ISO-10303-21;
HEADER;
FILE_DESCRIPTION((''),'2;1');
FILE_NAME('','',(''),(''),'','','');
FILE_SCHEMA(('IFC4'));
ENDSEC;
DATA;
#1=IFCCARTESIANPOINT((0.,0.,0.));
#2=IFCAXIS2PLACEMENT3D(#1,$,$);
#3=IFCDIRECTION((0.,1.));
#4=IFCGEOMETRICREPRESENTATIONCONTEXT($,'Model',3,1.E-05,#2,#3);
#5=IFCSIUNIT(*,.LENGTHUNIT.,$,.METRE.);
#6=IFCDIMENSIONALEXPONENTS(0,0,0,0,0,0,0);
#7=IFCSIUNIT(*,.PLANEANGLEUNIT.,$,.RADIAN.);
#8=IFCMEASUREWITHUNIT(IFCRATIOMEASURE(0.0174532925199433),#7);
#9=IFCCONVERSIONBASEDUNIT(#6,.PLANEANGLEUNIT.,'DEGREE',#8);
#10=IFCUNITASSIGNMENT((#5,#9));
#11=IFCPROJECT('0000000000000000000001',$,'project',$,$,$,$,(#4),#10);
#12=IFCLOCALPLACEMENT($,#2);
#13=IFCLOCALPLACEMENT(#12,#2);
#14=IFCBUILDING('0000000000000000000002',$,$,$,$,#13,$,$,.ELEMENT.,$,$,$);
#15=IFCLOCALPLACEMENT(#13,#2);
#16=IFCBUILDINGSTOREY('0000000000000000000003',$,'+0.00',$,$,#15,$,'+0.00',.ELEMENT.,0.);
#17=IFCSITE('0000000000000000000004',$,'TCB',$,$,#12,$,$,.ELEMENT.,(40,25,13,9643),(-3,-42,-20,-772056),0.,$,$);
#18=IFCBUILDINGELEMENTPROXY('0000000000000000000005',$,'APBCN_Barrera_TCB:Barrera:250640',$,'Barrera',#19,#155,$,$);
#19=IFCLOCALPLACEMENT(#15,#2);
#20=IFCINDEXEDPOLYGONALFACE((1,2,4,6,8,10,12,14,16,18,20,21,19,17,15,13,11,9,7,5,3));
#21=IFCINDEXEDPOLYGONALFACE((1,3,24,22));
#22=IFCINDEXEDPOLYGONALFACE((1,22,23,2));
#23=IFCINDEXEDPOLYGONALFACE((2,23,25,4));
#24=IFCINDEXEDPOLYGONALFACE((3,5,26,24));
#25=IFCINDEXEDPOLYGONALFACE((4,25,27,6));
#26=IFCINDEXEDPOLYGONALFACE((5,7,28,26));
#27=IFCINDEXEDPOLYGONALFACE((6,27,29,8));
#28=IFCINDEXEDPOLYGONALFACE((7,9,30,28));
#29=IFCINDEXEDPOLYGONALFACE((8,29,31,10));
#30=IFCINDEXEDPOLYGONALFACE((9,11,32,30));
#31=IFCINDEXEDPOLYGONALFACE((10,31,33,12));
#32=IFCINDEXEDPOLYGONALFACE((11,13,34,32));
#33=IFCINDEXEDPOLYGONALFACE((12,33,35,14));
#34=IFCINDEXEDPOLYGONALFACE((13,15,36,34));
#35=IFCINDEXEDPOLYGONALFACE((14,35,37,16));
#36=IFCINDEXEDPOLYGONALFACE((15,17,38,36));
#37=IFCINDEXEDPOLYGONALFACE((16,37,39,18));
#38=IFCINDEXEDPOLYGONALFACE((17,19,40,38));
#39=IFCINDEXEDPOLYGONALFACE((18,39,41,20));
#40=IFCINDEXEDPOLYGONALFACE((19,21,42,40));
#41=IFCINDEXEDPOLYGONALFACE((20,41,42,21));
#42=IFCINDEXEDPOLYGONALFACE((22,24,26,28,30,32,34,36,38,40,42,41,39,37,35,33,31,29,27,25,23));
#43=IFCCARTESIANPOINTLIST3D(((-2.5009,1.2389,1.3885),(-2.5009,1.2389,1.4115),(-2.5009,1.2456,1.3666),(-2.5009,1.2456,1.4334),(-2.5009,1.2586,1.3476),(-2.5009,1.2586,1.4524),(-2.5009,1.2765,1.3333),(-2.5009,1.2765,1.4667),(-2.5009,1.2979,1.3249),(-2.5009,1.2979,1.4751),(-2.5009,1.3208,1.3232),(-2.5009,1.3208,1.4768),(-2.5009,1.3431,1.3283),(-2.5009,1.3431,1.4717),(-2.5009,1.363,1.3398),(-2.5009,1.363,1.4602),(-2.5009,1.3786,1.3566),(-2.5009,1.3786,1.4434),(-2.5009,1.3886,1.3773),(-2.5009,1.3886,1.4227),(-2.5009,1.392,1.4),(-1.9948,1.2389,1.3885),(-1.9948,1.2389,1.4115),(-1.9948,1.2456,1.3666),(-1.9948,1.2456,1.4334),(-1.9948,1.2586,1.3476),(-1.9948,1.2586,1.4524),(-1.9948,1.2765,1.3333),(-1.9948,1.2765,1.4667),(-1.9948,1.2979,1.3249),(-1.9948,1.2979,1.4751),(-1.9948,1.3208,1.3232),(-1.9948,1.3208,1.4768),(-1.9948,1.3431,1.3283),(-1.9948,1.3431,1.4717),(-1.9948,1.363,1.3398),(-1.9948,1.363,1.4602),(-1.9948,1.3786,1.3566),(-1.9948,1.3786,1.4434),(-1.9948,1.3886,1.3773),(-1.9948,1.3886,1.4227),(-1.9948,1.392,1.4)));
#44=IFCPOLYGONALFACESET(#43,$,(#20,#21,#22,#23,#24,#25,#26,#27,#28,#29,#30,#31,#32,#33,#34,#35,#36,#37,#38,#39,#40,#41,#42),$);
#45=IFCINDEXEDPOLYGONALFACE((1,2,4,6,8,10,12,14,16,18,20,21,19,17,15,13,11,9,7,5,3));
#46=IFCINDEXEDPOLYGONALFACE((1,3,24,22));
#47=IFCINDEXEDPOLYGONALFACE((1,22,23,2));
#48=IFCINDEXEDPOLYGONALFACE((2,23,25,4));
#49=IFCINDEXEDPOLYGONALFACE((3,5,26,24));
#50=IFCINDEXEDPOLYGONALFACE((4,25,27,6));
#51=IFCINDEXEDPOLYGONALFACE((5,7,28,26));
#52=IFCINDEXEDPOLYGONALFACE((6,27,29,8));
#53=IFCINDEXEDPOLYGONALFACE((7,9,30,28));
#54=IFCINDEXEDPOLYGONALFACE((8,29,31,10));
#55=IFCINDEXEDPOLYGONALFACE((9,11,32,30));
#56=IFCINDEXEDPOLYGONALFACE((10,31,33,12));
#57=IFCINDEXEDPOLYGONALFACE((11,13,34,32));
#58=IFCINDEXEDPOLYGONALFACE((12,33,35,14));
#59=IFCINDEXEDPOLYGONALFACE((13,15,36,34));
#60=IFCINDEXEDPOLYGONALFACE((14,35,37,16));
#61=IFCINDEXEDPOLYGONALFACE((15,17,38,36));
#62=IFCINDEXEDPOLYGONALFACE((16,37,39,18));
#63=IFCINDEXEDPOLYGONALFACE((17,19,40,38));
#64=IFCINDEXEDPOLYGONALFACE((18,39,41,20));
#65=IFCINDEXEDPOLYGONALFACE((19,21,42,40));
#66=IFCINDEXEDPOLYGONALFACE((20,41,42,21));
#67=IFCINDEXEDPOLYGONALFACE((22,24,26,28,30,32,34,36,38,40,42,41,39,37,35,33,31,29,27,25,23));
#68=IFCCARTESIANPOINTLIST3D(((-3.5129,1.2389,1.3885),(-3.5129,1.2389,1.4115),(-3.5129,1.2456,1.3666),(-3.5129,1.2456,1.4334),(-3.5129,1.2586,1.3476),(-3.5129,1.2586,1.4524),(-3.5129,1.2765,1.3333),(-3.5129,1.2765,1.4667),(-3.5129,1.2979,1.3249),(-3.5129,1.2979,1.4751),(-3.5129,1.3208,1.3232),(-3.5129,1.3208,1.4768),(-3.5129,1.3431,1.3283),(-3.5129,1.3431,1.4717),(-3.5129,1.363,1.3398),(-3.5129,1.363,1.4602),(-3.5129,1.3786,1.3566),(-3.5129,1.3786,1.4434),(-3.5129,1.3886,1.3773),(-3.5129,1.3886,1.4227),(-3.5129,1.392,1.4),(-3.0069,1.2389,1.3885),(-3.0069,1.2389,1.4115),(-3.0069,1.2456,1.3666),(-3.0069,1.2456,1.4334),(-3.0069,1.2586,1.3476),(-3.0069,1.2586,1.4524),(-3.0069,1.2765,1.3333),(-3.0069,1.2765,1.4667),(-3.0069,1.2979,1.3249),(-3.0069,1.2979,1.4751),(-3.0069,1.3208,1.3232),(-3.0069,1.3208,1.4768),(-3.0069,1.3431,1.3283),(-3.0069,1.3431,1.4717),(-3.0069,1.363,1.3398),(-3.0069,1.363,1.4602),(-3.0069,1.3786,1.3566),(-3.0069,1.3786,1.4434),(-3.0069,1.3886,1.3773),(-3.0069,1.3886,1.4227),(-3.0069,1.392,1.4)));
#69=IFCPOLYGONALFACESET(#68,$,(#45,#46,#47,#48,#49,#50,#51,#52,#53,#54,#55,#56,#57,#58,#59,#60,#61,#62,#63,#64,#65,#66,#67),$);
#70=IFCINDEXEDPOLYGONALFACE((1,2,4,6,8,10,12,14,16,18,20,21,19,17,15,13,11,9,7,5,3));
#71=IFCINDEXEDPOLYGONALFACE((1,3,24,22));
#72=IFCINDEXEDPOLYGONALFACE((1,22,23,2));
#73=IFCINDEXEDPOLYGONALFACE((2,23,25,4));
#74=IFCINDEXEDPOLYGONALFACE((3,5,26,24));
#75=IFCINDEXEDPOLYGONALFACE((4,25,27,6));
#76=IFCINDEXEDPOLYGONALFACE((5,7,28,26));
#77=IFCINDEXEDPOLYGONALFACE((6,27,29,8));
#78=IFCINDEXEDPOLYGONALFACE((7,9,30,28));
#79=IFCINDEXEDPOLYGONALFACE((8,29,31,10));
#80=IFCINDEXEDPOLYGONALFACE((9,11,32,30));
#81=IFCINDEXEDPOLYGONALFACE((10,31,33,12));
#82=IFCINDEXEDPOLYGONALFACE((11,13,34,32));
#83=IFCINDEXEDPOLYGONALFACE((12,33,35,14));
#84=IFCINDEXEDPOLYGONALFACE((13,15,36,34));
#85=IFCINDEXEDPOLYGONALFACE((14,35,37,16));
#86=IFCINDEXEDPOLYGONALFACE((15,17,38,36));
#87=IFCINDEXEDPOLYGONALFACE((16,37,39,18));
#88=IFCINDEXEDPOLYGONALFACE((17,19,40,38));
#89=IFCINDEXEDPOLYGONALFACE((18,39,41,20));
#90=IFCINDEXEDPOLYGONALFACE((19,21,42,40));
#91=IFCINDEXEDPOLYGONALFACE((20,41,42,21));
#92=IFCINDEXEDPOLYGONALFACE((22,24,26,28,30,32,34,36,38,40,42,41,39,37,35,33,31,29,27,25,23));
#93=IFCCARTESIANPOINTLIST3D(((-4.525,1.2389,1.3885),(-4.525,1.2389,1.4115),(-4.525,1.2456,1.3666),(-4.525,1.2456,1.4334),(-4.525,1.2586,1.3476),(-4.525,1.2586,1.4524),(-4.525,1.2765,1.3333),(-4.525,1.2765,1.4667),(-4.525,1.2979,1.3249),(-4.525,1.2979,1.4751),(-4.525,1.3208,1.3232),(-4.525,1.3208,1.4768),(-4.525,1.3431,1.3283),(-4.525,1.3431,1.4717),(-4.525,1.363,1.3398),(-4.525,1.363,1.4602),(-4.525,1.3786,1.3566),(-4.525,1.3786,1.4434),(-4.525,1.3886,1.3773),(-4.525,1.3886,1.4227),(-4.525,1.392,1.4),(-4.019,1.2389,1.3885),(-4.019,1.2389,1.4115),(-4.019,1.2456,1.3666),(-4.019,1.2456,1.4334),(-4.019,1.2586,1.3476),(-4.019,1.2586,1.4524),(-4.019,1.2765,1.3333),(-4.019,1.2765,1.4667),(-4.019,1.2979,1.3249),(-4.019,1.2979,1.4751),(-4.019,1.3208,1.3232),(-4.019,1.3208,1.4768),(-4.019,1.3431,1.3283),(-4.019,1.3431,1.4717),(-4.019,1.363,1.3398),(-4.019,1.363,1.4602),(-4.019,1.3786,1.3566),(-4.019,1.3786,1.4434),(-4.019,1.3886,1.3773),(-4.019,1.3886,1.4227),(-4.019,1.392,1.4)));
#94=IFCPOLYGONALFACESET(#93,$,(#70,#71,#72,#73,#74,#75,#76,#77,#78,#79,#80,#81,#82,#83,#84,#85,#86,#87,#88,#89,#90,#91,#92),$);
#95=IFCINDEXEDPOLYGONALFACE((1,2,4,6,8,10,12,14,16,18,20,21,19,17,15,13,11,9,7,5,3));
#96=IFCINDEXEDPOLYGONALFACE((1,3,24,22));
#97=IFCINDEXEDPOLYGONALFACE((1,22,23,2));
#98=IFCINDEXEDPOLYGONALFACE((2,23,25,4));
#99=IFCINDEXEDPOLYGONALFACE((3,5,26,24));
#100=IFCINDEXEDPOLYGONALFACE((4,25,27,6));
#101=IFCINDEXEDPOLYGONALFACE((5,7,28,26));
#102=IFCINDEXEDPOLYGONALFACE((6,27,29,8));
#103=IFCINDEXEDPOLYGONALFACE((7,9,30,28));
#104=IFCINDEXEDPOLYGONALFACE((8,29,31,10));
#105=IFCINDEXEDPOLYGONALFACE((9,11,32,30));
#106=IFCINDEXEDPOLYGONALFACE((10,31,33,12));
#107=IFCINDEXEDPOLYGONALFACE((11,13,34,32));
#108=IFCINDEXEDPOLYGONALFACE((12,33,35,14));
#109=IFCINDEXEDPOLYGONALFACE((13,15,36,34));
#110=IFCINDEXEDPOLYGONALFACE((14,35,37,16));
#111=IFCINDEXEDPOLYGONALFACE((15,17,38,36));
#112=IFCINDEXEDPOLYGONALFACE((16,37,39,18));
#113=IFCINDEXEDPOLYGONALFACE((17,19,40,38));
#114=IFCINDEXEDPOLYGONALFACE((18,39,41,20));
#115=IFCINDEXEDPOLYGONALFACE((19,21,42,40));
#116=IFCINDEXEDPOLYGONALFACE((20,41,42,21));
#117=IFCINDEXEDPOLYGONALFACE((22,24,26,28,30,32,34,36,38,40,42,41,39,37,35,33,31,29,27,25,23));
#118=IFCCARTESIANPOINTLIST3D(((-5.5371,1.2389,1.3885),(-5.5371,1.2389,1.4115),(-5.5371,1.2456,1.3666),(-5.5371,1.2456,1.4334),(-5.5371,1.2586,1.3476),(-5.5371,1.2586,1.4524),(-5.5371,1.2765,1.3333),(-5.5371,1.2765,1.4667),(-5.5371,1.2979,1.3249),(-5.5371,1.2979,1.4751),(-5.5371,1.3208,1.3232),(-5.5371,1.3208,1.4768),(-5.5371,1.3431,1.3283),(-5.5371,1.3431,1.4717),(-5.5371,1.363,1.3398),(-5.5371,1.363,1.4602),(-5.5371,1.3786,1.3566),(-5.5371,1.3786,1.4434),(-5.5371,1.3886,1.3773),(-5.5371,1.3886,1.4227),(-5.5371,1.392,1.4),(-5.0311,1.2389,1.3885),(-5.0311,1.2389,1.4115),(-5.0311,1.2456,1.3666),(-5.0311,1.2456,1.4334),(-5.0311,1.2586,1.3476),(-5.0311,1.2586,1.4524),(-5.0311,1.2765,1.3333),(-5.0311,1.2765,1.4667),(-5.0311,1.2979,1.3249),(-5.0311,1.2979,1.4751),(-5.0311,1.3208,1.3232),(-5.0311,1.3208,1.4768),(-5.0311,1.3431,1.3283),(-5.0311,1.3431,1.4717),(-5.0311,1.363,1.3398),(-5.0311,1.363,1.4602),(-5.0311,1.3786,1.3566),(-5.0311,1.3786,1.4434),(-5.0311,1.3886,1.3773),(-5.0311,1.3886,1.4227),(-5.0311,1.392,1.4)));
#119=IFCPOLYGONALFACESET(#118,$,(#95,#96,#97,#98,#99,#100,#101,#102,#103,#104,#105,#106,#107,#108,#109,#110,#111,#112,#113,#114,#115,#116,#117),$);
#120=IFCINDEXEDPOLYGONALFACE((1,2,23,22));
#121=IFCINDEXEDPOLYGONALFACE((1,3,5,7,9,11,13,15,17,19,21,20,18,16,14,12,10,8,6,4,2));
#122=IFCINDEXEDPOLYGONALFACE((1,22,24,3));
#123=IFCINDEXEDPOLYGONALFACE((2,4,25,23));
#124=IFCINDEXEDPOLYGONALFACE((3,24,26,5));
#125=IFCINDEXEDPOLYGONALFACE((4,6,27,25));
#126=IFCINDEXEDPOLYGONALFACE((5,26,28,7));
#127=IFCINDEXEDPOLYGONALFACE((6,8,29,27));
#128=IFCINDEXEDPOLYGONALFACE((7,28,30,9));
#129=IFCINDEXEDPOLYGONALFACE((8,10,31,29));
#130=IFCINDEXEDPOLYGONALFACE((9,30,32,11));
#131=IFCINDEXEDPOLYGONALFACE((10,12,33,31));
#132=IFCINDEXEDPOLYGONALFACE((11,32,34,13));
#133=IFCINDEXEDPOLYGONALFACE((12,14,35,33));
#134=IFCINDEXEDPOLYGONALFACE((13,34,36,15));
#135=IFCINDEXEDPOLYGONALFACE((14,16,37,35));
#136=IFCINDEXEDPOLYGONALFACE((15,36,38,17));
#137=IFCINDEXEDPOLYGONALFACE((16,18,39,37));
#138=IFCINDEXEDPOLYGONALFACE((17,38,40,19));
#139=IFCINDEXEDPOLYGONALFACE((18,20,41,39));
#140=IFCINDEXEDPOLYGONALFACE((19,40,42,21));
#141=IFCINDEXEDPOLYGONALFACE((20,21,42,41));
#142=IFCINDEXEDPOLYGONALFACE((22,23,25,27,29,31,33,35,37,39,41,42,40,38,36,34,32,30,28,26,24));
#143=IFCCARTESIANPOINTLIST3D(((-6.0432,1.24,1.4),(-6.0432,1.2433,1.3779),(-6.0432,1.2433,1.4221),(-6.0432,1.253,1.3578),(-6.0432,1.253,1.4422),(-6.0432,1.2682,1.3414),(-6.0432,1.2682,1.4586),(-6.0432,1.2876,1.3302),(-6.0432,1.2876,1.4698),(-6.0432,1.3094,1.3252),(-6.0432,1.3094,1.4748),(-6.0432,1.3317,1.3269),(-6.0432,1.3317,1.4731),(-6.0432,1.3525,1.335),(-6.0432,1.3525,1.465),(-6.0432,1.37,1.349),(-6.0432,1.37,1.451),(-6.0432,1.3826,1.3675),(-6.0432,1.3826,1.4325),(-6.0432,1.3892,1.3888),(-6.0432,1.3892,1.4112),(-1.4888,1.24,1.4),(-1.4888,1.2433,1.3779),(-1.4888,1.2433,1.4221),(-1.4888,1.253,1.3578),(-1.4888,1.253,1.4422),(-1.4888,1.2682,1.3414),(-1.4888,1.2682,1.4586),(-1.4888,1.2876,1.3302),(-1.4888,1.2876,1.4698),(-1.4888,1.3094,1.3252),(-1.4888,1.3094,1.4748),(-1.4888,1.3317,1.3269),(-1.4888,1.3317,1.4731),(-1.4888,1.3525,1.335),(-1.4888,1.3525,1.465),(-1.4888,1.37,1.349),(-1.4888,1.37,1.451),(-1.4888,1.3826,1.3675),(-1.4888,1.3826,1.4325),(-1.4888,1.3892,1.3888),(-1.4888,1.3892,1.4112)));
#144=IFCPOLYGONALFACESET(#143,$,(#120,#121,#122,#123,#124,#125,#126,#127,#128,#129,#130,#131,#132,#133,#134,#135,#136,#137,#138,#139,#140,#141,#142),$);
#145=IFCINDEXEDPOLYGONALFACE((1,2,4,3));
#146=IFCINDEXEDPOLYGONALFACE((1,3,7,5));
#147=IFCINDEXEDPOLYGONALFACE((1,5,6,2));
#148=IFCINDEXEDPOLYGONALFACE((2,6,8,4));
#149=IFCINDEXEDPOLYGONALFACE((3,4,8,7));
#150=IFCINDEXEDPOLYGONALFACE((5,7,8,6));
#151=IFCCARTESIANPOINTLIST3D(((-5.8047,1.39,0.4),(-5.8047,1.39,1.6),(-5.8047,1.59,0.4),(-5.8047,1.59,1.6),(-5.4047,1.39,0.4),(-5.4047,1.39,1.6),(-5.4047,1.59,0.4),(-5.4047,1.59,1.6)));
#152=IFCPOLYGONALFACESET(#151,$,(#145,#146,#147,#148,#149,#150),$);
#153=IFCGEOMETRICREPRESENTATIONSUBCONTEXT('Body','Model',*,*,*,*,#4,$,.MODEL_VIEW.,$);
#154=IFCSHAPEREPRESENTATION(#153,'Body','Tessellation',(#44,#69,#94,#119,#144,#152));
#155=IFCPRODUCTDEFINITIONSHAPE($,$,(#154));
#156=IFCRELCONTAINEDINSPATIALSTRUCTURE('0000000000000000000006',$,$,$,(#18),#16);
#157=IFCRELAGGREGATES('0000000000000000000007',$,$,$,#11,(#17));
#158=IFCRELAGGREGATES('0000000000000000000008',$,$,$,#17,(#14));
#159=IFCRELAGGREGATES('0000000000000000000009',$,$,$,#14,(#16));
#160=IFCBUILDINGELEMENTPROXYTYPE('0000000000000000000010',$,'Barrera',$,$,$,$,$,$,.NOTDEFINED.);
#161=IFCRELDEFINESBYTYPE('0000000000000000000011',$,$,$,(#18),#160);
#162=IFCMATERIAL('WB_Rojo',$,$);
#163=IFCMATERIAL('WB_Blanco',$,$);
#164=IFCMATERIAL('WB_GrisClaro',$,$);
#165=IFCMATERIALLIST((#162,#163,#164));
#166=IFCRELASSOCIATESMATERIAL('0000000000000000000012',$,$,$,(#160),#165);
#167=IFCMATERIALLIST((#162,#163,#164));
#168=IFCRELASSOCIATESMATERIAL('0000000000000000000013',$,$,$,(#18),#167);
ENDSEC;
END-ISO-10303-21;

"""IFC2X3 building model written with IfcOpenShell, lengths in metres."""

from ifc_helpers import new_model, entity, si_unit, converted_unit, direction, frame, frame_2d, origin, place, context, subcontext, project, spatial, rectangle, circle, extrude, source, transform, mapped, material, material_list, type_object, type_shapes, element, save


model = new_model("IFC2X3")

# Units and contexts
model_context = context("Model", 3, precision=1e-05, world=origin(), true_north=direction((0.0, 1.0)))
body_context = subcontext(model_context, "Body", "Model", "MODEL_VIEW")
ifc_project = project(units=[si_unit("LENGTHUNIT", "METRE"), converted_unit("PLANEANGLEUNIT", "DEGREE", entity("IfcRatioMeasure", 0.0174532925199433), si_unit("PLANEANGLEUNIT", "RADIAN"), dimensions=[0, 0, 0, 0, 0, 0, 0])], contexts=[model_context])

# Site, building, storey
site_placement = place(None, origin())
site = spatial("IfcSite", under=ifc_project, at=site_placement, Name="TCB", CompositionType="ELEMENT", RefLatitude=(40, 25, 13, 9643), RefLongitude=(-3, -42, -20, -772056), RefElevation=0.0)
building_placement = place(site_placement, origin())
building = spatial("IfcBuilding", under=site, at=building_placement, CompositionType="ELEMENT")
storey_placement = place(building_placement, origin())
storey = spatial("IfcBuildingStorey", under=building, at=storey_placement, Name="+0.00", LongName="+0.00", CompositionType="ELEMENT", Elevation=0.0)

# Shared definitions
ifc_material_1 = material(Name="WB_GrisClaro")

# Shared definitions
ifc_material_2 = material(Name="WB_Blanco")

# Building element proxy
ifc_material_3 = material(Name="WB_Rojo")
ifc_material_list_1 = material_list([ifc_material_3, ifc_material_2, ifc_material_1])
ifc_material_list_2 = material_list([ifc_material_3, ifc_material_2, ifc_material_1])
building_element_proxy_type = type_object("IfcBuildingElementProxyType", Name="Barrera", PredefinedType="NOTDEFINED", material=ifc_material_list_2)
shared_shape_1 = source(origin(), body_context, "Body", "SweptSolid", [
    extrude(circle(Radius=0.077, at=frame_2d((0.0, 0.0), x_axis=(1.0, 0.0))), frame((2.8039, -0.175, 1.0), z_axis=(1.0, 0.0, 0.0), x_axis=(0.0, 1.0, 0.0)), (0.0, 0.0, 1.0), 0.506),
    extrude(circle(Radius=0.077, at=frame_2d((0.0, 0.0), x_axis=(1.0, 0.0))), frame((1.7918, -0.175, 1.0), z_axis=(1.0, 0.0, 0.0), x_axis=(0.0, 1.0, 0.0)), (0.0, 0.0, 1.0), 0.506),
    extrude(circle(Radius=0.077, at=frame_2d((0.0, 0.0), x_axis=(1.0, 0.0))), frame((0.7797, -0.175, 1.0), z_axis=(1.0, 0.0, 0.0), x_axis=(0.0, 1.0, 0.0)), (0.0, 0.0, 1.0), 0.506),
    extrude(circle(Radius=0.077, at=frame_2d((0.0, 0.0), x_axis=(1.0, 0.0))), frame((-0.2324, -0.175, 1.0), z_axis=(1.0, 0.0, 0.0), x_axis=(0.0, 1.0, 0.0)), (0.0, 0.0, 1.0), 0.506),
    extrude(circle(Radius=0.075, at=frame_2d((0.0, 0.0), x_axis=(1.0, 0.0))), frame((-0.7385, -0.175, 1.0), z_axis=(1.0, 0.0, 0.0), x_axis=(0.0, -1.0, 0.0)), (0.0, 0.0, 1.0), 4.5544),
    extrude(rectangle(XDim=0.2, YDim=0.4, at=frame_2d((0.0, 0.0), x_axis=(1.0, 0.0))), frame((-0.3, 0.0, 0.0), z_axis=(0.0, 0.0, 1.0), x_axis=(0.0, -1.0, 0.0)), (0.0, 0.0, 1.0), 1.2),
])
type_shapes(building_element_proxy_type, [shared_shape_1])
proxy_placement = place(storey_placement, frame((-5.3047, 1.49, 0.4)))
element("IfcBuildingElementProxy", 1, at=proxy_placement, inside=storey, type_object=building_element_proxy_type, material=ifc_material_list_1, Name="APBCN_Barrera_TCB:Barrera:250640", ObjectType="Barrera", context=body_context, shape_type="MappedRepresentation", body=[
    mapped(shared_shape_1, transform((0.0, 0.0, 0.0), scale=1.0)),
])

save(model, "model.ifc")
